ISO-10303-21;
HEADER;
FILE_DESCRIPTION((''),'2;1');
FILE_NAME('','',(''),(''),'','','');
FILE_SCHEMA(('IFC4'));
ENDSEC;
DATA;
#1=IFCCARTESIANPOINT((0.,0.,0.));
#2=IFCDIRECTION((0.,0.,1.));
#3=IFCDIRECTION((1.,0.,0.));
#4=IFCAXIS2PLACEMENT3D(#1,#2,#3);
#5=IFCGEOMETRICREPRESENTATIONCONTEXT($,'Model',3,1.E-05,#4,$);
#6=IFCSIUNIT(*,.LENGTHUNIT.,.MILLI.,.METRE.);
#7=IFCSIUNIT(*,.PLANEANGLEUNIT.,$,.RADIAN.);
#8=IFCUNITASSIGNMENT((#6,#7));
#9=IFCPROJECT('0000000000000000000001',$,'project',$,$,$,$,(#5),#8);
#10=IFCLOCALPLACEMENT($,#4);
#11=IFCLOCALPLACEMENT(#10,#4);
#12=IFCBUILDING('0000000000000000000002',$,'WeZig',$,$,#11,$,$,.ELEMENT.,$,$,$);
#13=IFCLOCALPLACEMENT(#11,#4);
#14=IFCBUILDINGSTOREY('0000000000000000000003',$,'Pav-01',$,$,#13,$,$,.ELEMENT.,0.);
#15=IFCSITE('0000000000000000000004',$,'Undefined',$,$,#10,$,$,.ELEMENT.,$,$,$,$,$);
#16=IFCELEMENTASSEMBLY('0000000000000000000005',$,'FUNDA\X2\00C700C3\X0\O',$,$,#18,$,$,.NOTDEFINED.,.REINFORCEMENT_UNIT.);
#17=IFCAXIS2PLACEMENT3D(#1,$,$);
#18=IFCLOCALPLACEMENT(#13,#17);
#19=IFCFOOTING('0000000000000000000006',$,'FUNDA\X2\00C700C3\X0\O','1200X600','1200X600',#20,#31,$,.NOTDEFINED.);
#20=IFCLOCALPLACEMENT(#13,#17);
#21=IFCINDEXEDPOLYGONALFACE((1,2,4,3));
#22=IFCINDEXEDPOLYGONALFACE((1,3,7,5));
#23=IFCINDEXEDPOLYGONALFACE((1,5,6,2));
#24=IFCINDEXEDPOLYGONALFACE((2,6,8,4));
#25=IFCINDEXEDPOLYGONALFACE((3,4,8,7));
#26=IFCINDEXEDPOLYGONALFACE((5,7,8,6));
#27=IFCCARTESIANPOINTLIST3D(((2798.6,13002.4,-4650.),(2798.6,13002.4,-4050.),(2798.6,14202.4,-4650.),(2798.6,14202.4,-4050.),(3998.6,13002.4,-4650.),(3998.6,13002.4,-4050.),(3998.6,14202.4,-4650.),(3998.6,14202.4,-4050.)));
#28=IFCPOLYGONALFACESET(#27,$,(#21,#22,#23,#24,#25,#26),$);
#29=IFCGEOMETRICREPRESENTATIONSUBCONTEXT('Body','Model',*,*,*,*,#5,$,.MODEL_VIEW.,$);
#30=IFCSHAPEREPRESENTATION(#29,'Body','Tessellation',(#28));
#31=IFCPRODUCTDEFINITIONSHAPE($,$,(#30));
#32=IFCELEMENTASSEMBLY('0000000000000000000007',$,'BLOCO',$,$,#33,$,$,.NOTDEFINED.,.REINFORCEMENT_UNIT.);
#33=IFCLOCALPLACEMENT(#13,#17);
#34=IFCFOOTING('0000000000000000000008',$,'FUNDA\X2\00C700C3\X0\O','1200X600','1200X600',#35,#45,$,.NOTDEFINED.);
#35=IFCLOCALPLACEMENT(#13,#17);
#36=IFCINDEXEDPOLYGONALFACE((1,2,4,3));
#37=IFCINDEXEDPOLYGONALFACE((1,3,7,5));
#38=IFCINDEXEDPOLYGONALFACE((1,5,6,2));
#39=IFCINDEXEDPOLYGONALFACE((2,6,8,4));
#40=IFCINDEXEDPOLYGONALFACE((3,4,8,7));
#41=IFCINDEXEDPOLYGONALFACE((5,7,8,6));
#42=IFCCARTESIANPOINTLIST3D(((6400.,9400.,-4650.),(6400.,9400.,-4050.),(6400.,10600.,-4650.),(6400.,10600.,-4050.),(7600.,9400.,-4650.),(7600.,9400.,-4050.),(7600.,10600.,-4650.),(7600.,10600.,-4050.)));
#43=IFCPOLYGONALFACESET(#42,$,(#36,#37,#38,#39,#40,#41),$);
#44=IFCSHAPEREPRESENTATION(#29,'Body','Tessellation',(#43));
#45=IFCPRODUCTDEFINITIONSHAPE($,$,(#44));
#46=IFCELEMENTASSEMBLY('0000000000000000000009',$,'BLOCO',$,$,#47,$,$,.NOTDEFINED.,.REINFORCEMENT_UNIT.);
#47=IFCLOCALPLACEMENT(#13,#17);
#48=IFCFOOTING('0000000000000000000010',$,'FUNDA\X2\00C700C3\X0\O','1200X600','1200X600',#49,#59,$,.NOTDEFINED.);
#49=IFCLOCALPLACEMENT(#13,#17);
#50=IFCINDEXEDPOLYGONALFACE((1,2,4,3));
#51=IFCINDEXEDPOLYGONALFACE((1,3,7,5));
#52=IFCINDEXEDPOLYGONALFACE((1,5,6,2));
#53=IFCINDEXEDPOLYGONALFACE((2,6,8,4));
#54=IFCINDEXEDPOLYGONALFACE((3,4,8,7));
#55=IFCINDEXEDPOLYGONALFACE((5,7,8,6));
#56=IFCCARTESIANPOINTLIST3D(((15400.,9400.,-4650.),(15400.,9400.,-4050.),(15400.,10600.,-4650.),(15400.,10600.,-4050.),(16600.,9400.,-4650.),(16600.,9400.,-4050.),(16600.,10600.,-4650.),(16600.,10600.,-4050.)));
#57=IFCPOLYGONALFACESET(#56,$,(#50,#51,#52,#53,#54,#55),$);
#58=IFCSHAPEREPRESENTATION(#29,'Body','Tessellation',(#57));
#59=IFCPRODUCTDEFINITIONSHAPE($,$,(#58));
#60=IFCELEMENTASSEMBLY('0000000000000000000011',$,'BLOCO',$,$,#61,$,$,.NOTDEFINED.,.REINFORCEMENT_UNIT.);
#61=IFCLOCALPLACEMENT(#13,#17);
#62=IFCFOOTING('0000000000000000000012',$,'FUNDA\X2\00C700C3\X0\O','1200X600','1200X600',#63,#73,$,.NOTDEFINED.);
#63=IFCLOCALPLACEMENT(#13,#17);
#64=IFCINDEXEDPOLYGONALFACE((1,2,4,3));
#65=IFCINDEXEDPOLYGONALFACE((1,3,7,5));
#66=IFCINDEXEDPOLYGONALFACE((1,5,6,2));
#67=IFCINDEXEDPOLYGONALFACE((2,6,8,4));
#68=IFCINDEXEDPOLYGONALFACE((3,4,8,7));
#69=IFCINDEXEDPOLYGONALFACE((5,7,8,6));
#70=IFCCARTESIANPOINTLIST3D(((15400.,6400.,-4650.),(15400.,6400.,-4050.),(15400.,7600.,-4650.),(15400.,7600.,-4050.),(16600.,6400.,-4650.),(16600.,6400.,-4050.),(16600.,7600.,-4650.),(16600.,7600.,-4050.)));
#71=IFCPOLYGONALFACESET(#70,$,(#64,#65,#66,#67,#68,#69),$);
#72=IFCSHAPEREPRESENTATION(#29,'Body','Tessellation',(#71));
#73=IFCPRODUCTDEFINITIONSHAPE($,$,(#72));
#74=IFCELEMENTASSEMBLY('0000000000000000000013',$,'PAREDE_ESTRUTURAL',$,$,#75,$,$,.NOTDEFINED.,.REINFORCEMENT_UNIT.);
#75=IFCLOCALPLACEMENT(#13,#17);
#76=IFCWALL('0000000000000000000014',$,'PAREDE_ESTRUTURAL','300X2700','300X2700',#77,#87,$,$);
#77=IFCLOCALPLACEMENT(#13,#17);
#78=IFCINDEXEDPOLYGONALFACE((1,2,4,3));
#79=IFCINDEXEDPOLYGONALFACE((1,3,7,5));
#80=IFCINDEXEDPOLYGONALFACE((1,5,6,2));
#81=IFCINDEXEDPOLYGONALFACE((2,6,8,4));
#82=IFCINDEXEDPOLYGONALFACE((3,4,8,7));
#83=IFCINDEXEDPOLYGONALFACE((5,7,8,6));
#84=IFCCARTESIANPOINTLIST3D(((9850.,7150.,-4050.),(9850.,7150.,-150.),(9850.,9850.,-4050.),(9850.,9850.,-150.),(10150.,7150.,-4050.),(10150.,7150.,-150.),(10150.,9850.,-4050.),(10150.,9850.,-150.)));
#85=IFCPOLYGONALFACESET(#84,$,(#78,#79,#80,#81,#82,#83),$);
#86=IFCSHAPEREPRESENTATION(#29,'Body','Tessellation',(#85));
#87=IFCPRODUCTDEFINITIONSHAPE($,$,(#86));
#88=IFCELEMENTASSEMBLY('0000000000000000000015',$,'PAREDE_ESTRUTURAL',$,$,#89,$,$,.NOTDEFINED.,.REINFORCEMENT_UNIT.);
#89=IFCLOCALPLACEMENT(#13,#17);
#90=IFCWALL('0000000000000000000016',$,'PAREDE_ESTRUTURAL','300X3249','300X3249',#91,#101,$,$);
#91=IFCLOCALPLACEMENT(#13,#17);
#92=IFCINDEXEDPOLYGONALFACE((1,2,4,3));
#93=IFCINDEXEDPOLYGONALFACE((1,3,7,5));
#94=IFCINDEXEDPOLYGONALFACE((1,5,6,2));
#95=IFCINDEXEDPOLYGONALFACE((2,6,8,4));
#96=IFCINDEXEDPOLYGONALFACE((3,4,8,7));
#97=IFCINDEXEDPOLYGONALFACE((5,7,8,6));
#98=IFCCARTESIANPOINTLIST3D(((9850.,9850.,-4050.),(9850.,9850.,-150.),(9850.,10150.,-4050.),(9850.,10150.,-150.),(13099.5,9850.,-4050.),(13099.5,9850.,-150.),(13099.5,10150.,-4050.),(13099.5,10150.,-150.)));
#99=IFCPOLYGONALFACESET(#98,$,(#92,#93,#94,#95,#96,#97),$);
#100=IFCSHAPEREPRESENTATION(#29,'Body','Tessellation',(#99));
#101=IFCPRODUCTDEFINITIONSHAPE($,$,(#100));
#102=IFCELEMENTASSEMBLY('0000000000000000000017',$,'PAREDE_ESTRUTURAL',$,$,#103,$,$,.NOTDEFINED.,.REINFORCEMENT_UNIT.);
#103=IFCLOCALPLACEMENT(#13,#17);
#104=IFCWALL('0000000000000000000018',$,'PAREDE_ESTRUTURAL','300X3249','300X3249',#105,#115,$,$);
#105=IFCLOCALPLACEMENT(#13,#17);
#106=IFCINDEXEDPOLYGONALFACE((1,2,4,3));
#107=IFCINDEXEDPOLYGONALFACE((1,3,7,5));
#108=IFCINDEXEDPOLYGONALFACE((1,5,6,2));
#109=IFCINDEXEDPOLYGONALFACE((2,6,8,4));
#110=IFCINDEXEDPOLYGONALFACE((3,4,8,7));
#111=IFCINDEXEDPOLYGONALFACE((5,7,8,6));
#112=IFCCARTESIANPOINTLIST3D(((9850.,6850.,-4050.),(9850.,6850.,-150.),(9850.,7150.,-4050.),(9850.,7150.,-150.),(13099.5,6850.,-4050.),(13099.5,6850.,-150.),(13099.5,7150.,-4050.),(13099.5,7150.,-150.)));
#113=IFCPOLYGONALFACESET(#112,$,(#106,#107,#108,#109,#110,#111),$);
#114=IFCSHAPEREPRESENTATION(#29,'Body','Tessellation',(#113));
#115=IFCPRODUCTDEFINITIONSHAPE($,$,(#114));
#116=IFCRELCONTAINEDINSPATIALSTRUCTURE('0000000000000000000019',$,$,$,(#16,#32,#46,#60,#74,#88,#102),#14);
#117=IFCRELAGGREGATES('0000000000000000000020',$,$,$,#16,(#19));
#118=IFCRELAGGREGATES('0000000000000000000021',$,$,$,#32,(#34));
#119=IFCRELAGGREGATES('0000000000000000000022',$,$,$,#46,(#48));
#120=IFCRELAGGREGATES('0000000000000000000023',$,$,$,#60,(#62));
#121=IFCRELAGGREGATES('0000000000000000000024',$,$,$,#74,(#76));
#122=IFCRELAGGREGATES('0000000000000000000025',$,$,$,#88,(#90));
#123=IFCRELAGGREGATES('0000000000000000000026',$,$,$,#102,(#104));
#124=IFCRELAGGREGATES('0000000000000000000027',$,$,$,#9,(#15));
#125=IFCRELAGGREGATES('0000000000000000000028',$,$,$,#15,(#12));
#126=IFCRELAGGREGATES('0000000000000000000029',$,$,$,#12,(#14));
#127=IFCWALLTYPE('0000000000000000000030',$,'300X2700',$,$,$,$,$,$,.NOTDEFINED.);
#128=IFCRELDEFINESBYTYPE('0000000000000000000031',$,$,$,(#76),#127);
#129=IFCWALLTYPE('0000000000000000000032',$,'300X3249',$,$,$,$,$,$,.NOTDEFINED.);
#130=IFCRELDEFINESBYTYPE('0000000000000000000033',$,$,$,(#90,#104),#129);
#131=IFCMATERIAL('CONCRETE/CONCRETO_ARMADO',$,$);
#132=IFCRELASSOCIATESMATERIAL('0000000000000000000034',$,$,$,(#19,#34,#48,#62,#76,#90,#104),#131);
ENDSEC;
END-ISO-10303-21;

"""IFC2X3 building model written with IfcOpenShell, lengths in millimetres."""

from ifc_helpers import new_model, si_unit, frame, frame_2d, origin_with_axes, origin_2d_with_axis, place, context, subcontext, project, spatial, rectangle, extrude, material, type_object, element, aggregate, save


model = new_model("IFC2X3")

# Units and contexts
model_context = context("Model", 3, precision=1e-05, world=origin_with_axes())
body_context = subcontext(model_context, "Body", "Model", "MODEL_VIEW")
ifc_project = project(units=[si_unit("LENGTHUNIT", "METRE", prefix="MILLI"), si_unit("PLANEANGLEUNIT", "RADIAN")], contexts=[model_context])

# Site, building, storey
site_placement = place(None, origin_with_axes())
site = spatial("IfcSite", under=ifc_project, at=site_placement, Name="Undefined", CompositionType="ELEMENT")
building_placement = place(site_placement, origin_with_axes())
building = spatial("IfcBuilding", under=site, at=building_placement, Name="WeZig", CompositionType="ELEMENT")
storey_placement = place(building_placement, origin_with_axes())
storey = spatial("IfcBuildingStorey", under=building, at=storey_placement, Name="Pav-01", CompositionType="ELEMENT", Elevation=0.0)

# Element assemblies, footings
assembly_1_placement = place(storey_placement, origin_with_axes())
assembly_1 = element("IfcElementAssembly", 1, at=assembly_1_placement, inside=storey, Name="FUNDAÇÃO", AssemblyPlace="NOTDEFINED", PredefinedType="REINFORCEMENT_UNIT")
ifc_material_1 = material(Name="CONCRETE/CONCRETO_ARMADO")
footing_1_placement = place(assembly_1_placement, frame((3398.6, 13602.4, -4650.0), z_axis=(0.0, 1.0, 0.0), x_axis=(0.0, 0.0, 1.0)))
footing_1 = element("IfcFooting", 2, at=footing_1_placement, material=ifc_material_1, Name="FUNDAÇÃO", Description="1200X600", ObjectType="1200X600", PredefinedType="NOTDEFINED", context=body_context, shape_type="SweptSolid", body=[
    extrude(rectangle(XDim=1200.0, YDim=1200.0, at=origin_2d_with_axis()), frame((600.0, 0.0, 0.0), z_axis=(-1.0, 0.0, 0.0), x_axis=(0.0, -1.0, 0.0)), (0.0, 0.0, 1.0), 600.0),
])
aggregate(assembly_1, [footing_1])
assembly_2_placement = place(storey_placement, origin_with_axes())
assembly_2 = element("IfcElementAssembly", 3, at=assembly_2_placement, inside=storey, Name="BLOCO", AssemblyPlace="NOTDEFINED", PredefinedType="REINFORCEMENT_UNIT")
footing_2_placement = place(assembly_2_placement, frame((7000.0, 10000.0, -4650.0), z_axis=(0.0, 1.0, 0.0), x_axis=(0.0, 0.0, 1.0)))
footing_2 = element("IfcFooting", 4, at=footing_2_placement, material=ifc_material_1, Name="FUNDAÇÃO", Description="1200X600", ObjectType="1200X600", PredefinedType="NOTDEFINED", context=body_context, shape_type="SweptSolid", body=[
    extrude(rectangle(XDim=1200.0, YDim=1200.0, at=origin_2d_with_axis()), frame((600.0, 0.0, 0.0), z_axis=(-1.0, 0.0, 0.0), x_axis=(0.0, -1.0, 0.0)), (0.0, 0.0, 1.0), 600.0),
])
aggregate(assembly_2, [footing_2])
assembly_3_placement = place(storey_placement, origin_with_axes())
assembly_3 = element("IfcElementAssembly", 5, at=assembly_3_placement, inside=storey, Name="BLOCO", AssemblyPlace="NOTDEFINED", PredefinedType="REINFORCEMENT_UNIT")
footing_3_placement = place(assembly_3_placement, frame((16000.0, 10000.0, -4650.0), z_axis=(0.0, 1.0, 0.0), x_axis=(0.0, 0.0, 1.0)))
footing_3 = element("IfcFooting", 6, at=footing_3_placement, material=ifc_material_1, Name="FUNDAÇÃO", Description="1200X600", ObjectType="1200X600", PredefinedType="NOTDEFINED", context=body_context, shape_type="SweptSolid", body=[
    extrude(rectangle(XDim=1200.0, YDim=1200.0, at=origin_2d_with_axis()), frame((600.0, 0.0, 0.0), z_axis=(-1.0, 0.0, 0.0), x_axis=(0.0, -1.0, 0.0)), (0.0, 0.0, 1.0), 600.0),
])
aggregate(assembly_3, [footing_3])
assembly_4_placement = place(storey_placement, origin_with_axes())
assembly_4 = element("IfcElementAssembly", 7, at=assembly_4_placement, inside=storey, Name="BLOCO", AssemblyPlace="NOTDEFINED", PredefinedType="REINFORCEMENT_UNIT")
footing_4_placement = place(assembly_4_placement, frame((16000.0, 7000.0, -4650.0), z_axis=(0.0, 1.0, 0.0), x_axis=(0.0, 0.0, 1.0)))
footing_4 = element("IfcFooting", 8, at=footing_4_placement, material=ifc_material_1, Name="FUNDAÇÃO", Description="1200X600", ObjectType="1200X600", PredefinedType="NOTDEFINED", context=body_context, shape_type="SweptSolid", body=[
    extrude(rectangle(XDim=1200.0, YDim=1200.0, at=origin_2d_with_axis()), frame((600.0, 0.0, 0.0), z_axis=(-1.0, 0.0, 0.0), x_axis=(0.0, -1.0, 0.0)), (0.0, 0.0, 1.0), 600.0),
])
aggregate(assembly_4, [footing_4])

# Element assemblies, walls
assembly_5_placement = place(storey_placement, origin_with_axes())
assembly_5 = element("IfcElementAssembly", 9, at=assembly_5_placement, inside=storey, Name="PAREDE_ESTRUTURAL", AssemblyPlace="NOTDEFINED", PredefinedType="REINFORCEMENT_UNIT")
wall_type_1 = type_object("IfcWallType", Name="300X2700", PredefinedType="NOTDEFINED")
wall_1_placement = place(assembly_5_placement, frame((10000.0, 9850.0, -3450.0), z_axis=(0.0, 0.0, 1.0), x_axis=(0.0, -1.0, 0.0)))
wall_1 = element("IfcWall", 10, at=wall_1_placement, type_object=wall_type_1, material=ifc_material_1, Name="PAREDE_ESTRUTURAL", Description="300X2700", ObjectType="300X2700", context=body_context, shape_type="SweptSolid", body=[
    extrude(rectangle(XDim=2700.0, YDim=300.0, at=frame_2d((0.0, 1350.0), x_axis=(0.0, -1.0))), frame((0.0, 0.0, -600.0), z_axis=(0.0, 0.0, 1.0), x_axis=(0.0, -1.0, 0.0)), (0.0, 0.0, 1.0), 3900.0),
])
assembly_6_placement = place(storey_placement, origin_with_axes())
assembly_6 = element("IfcElementAssembly", 11, at=assembly_6_placement, inside=storey, Name="PAREDE_ESTRUTURAL", AssemblyPlace="NOTDEFINED", PredefinedType="REINFORCEMENT_UNIT")
wall_type_2 = type_object("IfcWallType", Name="300X3249", PredefinedType="NOTDEFINED")
wall_2_placement = place(assembly_6_placement, frame((13099.5, 10000.0, -3724.8), z_axis=(0.0, 0.0, 1.0), x_axis=(-1.0, 0.0, 0.0)))
wall_2 = element("IfcWall", 12, at=wall_2_placement, type_object=wall_type_2, material=ifc_material_1, Name="PAREDE_ESTRUTURAL", Description="300X3249", ObjectType="300X3249", context=body_context, shape_type="SweptSolid", body=[
    extrude(rectangle(XDim=3249.5, YDim=300.0, at=frame_2d((0.0, 1624.8), x_axis=(0.0, -1.0))), frame((0.0, 0.0, -325.2), z_axis=(0.0, 0.0, 1.0), x_axis=(0.0, -1.0, 0.0)), (0.0, 0.0, 1.0), 3900.0),
])
assembly_7_placement = place(storey_placement, origin_with_axes())
assembly_7 = element("IfcElementAssembly", 13, at=assembly_7_placement, inside=storey, Name="PAREDE_ESTRUTURAL", AssemblyPlace="NOTDEFINED", PredefinedType="REINFORCEMENT_UNIT")
wall_3_placement = place(assembly_7_placement, frame((9850.0, 7000.0, -3724.8), z_axis=(0.0, 0.0, 1.0), x_axis=(1.0, 0.0, 0.0)))
wall_3 = element("IfcWall", 14, at=wall_3_placement, type_object=wall_type_2, material=ifc_material_1, Name="PAREDE_ESTRUTURAL", Description="300X3249", ObjectType="300X3249", context=body_context, shape_type="SweptSolid", body=[
    extrude(rectangle(XDim=3249.5, YDim=300.0, at=frame_2d((0.0, 1624.7), x_axis=(0.0, -1.0))), frame((0.0, 0.0, -325.2), z_axis=(0.0, 0.0, 1.0), x_axis=(0.0, -1.0, 0.0)), (0.0, 0.0, 1.0), 3900.0),
])

aggregate(assembly_5, [wall_1])
aggregate(assembly_6, [wall_2])
aggregate(assembly_7, [wall_3])

save(model, "model.ifc")
